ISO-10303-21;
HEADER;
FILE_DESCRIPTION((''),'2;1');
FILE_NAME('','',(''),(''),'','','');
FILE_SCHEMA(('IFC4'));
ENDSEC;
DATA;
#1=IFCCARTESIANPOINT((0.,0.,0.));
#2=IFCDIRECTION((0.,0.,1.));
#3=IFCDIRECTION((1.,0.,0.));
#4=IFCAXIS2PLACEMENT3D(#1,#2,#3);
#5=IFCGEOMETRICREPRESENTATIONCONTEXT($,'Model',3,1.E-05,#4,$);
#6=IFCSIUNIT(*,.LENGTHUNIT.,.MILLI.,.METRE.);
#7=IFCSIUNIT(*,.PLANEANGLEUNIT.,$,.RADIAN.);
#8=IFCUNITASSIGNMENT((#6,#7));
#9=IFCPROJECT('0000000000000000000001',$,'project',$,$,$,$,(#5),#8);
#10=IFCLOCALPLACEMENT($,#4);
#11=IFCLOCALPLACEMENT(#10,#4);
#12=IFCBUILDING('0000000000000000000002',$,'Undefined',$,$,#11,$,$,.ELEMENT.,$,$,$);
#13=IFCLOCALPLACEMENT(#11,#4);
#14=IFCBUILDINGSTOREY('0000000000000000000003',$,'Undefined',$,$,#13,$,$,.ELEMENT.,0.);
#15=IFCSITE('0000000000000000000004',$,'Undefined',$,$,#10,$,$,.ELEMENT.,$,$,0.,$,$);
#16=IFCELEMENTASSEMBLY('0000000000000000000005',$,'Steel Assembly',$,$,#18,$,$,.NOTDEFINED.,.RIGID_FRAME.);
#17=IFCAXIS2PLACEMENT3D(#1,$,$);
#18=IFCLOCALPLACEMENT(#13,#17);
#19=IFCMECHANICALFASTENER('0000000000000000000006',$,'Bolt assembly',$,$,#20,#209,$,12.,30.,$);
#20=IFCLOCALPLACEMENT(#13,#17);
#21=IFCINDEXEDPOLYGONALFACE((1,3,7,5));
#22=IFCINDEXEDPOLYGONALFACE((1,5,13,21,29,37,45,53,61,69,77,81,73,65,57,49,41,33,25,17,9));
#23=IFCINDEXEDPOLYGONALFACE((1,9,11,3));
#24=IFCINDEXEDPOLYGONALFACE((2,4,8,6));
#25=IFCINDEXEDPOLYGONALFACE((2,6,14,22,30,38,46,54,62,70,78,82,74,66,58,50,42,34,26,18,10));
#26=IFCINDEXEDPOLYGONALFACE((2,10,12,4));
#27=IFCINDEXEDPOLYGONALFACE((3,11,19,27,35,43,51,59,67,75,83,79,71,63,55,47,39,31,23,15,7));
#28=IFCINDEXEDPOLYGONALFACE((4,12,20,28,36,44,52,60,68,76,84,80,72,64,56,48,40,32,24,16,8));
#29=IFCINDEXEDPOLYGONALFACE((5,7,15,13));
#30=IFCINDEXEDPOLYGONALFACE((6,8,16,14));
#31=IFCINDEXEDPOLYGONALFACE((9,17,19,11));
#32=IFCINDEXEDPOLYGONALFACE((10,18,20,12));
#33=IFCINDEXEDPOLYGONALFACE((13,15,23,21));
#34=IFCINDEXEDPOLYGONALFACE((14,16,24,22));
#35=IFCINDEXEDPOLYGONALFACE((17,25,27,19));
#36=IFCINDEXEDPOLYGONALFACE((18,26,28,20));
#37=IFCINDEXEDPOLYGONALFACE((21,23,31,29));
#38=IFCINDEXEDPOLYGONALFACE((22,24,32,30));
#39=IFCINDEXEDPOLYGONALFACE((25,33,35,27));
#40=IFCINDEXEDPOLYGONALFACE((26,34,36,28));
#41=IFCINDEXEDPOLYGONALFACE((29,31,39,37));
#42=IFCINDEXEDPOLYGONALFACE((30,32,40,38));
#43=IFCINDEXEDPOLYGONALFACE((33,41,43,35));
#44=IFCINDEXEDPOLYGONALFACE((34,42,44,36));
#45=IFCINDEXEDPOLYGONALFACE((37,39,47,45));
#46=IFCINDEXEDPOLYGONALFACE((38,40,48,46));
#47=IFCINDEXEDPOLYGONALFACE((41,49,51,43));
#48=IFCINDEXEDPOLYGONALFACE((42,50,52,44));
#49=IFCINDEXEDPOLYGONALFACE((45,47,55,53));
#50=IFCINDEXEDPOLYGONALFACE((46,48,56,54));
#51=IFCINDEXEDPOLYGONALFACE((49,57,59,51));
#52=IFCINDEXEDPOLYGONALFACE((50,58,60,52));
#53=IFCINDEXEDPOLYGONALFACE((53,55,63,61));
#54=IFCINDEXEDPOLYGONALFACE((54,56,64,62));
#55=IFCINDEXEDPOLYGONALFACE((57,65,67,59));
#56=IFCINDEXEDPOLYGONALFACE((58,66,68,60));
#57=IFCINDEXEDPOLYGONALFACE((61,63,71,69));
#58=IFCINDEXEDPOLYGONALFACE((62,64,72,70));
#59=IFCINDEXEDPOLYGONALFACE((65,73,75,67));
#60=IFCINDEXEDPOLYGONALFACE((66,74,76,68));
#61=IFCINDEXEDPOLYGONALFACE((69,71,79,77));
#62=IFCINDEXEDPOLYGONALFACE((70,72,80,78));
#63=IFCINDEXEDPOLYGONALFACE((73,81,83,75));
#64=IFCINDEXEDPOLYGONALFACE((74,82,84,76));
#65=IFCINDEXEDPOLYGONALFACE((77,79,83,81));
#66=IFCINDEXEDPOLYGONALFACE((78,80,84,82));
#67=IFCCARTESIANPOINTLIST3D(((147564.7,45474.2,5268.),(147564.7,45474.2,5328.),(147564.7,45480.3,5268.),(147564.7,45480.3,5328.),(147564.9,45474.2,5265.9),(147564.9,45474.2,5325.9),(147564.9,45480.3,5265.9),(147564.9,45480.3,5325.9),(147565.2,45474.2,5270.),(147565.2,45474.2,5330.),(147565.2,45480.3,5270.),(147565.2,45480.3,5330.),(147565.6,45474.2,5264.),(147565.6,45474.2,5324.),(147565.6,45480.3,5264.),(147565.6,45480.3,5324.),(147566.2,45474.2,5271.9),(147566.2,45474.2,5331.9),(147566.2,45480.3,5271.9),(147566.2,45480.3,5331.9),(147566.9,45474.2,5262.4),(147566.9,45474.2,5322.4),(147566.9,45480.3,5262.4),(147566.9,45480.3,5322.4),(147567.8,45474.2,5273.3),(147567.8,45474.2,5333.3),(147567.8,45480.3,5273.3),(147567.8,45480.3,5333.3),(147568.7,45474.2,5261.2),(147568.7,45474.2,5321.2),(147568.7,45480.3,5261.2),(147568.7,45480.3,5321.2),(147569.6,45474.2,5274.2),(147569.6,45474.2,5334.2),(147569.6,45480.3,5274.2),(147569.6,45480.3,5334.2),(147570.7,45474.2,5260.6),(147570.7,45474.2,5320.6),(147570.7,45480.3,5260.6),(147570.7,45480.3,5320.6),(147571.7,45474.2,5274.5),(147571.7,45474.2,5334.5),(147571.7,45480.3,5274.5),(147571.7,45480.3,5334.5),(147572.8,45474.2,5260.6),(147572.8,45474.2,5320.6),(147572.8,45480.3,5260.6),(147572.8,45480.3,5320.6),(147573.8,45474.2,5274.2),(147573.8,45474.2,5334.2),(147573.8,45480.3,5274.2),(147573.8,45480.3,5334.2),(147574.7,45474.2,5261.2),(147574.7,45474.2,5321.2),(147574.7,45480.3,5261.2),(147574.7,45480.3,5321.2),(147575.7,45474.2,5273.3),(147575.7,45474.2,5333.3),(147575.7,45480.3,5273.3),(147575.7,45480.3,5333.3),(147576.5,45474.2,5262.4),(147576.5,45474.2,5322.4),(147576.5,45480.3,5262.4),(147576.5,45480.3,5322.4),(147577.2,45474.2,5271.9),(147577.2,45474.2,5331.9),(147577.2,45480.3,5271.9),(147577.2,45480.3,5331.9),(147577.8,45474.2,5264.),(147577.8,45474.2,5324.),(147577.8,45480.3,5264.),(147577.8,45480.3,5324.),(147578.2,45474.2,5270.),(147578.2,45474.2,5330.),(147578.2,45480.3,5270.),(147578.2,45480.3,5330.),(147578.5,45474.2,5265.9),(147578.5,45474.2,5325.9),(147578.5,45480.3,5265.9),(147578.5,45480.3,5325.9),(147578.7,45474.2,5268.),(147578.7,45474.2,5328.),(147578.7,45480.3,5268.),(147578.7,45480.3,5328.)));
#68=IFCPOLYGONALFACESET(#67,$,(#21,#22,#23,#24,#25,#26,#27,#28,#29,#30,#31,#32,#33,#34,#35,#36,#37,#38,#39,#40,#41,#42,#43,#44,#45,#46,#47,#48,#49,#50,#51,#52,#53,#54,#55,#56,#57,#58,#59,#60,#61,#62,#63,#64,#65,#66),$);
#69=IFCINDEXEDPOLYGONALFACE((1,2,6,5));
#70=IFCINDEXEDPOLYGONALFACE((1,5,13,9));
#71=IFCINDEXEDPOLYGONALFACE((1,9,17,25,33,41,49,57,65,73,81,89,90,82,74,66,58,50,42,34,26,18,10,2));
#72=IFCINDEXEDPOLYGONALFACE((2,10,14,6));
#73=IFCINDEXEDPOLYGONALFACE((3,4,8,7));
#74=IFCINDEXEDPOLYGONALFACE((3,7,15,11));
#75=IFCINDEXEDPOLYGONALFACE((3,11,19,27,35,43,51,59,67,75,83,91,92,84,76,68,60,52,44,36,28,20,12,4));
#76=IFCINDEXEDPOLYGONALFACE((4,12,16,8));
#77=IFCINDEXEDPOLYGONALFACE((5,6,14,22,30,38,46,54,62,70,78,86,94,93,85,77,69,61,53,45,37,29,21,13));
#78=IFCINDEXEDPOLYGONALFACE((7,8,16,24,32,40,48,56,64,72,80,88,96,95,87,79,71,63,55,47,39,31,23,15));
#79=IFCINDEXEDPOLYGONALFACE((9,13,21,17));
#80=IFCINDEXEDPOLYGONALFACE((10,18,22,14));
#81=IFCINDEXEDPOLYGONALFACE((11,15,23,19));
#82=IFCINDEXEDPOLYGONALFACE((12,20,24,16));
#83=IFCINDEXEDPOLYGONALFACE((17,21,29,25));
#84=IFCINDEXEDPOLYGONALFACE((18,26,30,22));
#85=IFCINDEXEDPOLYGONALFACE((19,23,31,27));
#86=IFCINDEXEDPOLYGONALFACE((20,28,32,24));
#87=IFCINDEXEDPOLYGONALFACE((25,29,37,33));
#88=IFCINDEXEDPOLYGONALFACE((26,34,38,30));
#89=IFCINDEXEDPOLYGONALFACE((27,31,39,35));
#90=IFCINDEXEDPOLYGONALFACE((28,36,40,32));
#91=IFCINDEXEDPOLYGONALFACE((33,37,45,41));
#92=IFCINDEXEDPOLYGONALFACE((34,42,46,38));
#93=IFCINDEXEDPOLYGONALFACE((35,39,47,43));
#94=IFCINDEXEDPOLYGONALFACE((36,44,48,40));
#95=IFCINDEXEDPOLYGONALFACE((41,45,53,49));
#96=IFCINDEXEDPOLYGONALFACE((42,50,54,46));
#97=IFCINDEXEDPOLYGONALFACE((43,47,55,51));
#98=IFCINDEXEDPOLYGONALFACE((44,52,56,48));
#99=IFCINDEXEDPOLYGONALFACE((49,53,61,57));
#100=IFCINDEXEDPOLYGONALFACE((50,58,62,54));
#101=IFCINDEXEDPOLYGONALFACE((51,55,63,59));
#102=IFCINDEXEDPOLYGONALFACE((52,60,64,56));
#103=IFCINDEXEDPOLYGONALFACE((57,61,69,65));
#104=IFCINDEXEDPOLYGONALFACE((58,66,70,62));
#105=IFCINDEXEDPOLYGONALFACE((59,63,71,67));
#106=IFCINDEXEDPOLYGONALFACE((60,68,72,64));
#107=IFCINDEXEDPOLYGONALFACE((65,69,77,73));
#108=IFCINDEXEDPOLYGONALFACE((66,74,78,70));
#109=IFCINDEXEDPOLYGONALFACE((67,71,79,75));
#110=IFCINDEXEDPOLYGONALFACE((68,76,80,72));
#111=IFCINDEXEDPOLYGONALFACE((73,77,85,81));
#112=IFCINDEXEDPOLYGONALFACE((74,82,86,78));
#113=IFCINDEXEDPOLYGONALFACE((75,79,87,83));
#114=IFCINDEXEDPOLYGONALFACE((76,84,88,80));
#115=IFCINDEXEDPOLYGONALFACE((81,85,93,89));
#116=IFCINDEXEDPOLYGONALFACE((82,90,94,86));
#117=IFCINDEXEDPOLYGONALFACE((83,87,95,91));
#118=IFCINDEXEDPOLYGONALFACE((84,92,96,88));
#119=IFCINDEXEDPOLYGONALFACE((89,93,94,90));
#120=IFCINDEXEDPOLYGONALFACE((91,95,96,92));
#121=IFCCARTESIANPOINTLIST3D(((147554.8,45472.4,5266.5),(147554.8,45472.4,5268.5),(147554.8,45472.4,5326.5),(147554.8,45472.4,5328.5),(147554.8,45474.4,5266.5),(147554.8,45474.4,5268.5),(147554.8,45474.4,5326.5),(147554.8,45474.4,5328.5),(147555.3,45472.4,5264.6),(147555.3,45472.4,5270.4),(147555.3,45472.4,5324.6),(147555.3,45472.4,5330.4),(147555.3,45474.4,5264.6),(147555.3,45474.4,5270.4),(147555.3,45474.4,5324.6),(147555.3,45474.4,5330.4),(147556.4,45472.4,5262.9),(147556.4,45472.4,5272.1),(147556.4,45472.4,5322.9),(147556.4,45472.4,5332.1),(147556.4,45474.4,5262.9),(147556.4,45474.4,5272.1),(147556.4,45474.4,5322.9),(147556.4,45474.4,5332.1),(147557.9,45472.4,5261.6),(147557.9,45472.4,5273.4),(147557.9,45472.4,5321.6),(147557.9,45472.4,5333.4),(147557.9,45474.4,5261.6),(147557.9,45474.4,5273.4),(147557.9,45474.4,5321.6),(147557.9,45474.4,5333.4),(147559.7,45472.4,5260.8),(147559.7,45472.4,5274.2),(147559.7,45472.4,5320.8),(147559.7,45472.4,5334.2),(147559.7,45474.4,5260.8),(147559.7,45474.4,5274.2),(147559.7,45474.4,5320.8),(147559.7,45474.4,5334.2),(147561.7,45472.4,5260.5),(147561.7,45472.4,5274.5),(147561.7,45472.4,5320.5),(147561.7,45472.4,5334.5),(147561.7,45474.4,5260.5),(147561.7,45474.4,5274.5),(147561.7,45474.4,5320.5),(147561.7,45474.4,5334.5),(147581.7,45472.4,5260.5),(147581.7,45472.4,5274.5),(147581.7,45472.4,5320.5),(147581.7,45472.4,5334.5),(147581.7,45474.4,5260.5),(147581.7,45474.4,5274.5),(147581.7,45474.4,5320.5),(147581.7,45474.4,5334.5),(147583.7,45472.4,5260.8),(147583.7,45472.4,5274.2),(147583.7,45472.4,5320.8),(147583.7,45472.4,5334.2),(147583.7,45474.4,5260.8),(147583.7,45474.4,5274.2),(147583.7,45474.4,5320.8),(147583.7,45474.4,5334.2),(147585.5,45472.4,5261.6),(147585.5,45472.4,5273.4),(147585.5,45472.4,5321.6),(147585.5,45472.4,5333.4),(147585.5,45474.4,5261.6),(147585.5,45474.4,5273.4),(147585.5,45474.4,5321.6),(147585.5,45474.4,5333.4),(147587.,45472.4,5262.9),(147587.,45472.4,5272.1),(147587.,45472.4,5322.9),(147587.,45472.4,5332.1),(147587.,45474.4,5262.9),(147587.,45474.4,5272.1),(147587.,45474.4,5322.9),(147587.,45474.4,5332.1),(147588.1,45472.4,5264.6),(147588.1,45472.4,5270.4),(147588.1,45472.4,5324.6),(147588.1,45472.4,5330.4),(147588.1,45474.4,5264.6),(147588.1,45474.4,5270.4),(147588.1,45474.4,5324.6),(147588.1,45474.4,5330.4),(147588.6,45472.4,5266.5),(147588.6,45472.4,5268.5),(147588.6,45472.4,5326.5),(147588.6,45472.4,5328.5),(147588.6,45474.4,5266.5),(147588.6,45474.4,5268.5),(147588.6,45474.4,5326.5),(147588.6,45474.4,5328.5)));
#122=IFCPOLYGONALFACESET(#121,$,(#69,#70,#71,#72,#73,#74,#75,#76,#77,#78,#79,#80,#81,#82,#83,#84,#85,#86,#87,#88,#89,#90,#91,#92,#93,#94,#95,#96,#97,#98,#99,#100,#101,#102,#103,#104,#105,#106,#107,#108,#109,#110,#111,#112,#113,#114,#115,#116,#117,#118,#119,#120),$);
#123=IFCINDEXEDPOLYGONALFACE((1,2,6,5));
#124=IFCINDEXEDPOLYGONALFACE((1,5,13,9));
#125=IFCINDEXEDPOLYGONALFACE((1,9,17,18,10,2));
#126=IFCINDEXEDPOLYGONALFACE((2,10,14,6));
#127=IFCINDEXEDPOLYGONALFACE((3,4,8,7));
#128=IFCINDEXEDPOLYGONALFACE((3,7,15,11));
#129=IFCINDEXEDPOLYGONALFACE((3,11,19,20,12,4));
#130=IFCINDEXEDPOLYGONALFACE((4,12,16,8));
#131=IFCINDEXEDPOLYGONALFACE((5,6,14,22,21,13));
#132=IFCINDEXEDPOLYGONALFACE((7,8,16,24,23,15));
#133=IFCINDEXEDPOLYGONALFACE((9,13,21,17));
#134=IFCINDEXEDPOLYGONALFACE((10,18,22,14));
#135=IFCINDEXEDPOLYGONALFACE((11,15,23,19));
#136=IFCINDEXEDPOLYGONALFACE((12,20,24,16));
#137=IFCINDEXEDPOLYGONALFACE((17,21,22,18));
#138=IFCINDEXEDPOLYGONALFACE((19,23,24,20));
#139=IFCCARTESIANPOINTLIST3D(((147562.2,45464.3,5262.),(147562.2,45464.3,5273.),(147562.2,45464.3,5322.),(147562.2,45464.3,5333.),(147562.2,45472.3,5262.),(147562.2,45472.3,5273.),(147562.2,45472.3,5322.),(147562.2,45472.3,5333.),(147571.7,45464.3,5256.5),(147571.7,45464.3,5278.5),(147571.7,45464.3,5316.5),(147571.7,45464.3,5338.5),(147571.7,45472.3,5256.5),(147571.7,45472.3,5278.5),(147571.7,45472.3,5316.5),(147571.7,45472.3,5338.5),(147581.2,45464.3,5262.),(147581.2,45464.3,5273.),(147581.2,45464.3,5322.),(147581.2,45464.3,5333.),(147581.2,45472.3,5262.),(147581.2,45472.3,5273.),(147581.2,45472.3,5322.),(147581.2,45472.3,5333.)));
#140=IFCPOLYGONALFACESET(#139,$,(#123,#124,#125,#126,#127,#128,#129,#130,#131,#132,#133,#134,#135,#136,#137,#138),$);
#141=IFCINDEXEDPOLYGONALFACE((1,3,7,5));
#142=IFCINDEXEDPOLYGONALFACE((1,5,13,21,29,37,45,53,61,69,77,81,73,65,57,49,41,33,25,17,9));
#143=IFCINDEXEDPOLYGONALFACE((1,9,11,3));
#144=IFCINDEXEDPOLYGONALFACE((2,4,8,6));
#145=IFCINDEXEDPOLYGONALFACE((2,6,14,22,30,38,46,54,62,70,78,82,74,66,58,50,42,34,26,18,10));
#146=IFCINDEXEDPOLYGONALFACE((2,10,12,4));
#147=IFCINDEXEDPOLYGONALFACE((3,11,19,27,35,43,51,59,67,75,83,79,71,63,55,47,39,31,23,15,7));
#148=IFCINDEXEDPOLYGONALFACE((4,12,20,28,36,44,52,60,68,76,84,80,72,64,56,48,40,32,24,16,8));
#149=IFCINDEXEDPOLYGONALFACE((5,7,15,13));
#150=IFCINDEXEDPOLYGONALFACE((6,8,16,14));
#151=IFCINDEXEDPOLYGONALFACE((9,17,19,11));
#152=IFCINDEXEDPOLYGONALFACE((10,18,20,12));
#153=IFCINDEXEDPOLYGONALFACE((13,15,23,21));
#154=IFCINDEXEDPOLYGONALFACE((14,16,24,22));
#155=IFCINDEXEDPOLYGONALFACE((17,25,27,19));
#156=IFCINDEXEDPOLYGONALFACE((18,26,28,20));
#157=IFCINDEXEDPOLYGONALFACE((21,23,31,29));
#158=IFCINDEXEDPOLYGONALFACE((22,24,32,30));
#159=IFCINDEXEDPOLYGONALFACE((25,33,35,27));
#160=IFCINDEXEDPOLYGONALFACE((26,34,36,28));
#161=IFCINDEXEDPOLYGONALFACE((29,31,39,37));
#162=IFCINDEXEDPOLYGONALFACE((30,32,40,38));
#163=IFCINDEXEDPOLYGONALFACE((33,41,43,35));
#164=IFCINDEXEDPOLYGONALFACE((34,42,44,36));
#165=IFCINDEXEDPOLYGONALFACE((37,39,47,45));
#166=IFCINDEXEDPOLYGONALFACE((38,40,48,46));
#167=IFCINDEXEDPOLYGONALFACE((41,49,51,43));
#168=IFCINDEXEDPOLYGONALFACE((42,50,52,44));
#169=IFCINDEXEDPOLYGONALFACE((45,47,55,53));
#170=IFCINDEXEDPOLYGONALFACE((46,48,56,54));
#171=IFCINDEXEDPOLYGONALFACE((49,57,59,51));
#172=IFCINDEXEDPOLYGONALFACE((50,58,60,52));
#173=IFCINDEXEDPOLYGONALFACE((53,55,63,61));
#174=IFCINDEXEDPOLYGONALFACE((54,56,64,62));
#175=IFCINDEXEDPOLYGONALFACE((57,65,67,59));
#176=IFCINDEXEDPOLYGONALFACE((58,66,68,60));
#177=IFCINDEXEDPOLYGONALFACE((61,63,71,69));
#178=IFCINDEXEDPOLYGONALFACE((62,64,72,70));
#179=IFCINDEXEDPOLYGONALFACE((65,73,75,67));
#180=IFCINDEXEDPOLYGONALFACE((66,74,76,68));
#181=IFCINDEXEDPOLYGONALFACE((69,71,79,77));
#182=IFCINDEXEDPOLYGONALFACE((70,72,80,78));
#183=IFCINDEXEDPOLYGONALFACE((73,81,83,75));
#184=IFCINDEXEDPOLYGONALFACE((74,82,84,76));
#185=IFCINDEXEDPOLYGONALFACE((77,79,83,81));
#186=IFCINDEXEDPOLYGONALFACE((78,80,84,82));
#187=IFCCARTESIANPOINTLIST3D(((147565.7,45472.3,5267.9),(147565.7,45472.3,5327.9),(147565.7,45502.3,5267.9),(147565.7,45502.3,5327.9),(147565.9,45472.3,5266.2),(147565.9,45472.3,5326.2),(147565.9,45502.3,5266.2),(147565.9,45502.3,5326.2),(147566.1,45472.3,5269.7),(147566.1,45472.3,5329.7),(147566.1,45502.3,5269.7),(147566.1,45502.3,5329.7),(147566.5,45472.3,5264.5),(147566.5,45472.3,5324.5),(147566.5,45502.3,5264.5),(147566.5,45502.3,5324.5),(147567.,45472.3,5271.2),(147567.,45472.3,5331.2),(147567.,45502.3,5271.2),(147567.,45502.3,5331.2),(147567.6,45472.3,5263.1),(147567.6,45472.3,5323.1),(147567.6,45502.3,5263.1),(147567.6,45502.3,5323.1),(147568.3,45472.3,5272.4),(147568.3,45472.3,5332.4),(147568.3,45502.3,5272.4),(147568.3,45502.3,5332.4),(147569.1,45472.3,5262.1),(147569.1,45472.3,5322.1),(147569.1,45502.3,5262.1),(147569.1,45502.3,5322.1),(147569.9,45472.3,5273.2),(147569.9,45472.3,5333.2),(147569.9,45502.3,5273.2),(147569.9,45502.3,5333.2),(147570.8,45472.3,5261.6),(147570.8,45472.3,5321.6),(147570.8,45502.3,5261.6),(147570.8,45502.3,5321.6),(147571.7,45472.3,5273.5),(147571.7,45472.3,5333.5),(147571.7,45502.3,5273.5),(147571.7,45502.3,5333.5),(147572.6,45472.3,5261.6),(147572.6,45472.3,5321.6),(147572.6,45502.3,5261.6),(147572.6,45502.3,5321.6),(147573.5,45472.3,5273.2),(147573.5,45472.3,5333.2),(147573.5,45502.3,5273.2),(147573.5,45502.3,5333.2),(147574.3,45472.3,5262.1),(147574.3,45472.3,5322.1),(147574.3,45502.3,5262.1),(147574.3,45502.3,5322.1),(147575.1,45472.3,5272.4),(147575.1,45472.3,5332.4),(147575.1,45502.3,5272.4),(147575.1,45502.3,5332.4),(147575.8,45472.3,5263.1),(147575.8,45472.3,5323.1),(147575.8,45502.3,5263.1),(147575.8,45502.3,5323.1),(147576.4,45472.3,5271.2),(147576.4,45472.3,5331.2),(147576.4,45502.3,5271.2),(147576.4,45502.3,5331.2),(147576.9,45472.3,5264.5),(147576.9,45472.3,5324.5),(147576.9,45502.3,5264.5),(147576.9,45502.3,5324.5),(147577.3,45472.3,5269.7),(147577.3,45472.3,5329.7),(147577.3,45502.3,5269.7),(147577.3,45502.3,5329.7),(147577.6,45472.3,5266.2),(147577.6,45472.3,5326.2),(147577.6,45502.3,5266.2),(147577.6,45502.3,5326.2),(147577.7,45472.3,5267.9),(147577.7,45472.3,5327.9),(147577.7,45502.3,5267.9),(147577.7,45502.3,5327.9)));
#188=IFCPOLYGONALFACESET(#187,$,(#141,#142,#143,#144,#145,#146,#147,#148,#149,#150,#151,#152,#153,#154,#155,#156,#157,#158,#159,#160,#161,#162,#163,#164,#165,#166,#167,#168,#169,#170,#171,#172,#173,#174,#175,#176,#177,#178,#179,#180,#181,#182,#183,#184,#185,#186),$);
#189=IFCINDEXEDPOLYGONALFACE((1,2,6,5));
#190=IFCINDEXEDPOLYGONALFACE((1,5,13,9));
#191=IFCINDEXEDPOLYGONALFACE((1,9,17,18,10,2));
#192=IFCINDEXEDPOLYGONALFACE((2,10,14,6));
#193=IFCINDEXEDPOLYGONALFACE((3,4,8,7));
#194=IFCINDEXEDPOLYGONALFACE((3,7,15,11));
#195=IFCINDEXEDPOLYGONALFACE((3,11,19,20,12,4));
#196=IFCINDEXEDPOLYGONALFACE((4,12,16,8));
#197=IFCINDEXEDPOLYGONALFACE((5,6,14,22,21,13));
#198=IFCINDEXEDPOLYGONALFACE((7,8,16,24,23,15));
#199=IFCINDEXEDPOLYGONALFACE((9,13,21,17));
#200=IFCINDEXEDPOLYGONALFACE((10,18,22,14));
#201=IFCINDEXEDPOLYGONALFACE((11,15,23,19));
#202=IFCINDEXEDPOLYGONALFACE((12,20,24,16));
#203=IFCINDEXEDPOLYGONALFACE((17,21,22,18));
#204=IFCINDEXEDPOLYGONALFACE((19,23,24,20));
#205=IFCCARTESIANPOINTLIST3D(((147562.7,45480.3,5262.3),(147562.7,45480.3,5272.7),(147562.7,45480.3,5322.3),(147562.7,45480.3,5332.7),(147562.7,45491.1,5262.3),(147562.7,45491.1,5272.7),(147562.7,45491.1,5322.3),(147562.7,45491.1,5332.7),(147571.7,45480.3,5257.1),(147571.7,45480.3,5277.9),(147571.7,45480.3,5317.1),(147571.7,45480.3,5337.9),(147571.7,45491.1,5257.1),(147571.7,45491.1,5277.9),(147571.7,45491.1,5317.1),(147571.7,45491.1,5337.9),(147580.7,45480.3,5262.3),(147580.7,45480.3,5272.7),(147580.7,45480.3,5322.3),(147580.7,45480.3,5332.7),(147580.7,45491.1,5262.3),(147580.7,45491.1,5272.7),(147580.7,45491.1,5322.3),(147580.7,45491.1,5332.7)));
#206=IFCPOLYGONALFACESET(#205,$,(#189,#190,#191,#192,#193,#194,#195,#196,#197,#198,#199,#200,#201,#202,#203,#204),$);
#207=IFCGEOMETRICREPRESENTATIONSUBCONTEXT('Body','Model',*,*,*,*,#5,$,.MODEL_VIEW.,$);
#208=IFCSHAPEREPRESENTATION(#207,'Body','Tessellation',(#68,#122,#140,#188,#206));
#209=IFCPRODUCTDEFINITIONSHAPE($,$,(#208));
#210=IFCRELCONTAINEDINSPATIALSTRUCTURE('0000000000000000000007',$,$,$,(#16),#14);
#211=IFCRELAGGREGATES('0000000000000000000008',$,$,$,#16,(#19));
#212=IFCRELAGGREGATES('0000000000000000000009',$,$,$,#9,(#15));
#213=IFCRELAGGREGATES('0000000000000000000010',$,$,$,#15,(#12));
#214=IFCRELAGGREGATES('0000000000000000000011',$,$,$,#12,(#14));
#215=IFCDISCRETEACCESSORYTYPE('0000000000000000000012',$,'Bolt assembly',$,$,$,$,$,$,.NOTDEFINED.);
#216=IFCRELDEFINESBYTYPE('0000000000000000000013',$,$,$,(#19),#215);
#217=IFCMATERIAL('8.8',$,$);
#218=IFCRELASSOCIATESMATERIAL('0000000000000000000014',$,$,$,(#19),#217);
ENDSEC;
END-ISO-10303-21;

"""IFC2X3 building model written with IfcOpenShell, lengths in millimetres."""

from ifc_helpers import new_model, si_unit, frame, frame_2d, origin_with_axes, origin_2d_with_axis, place, context, subcontext, project, spatial, polyline, circle_curve, parameter, trimmed, segment, composite_curve, circle, outline, extrude, source, transform, mapped, material, type_object, element, aggregate, save


model = new_model("IFC2X3")

# Units and contexts
model_context = context("Model", 3, precision=1e-05, world=origin_with_axes())
body_context = subcontext(model_context, "Body", "Model", "MODEL_VIEW")
ifc_project = project(units=[si_unit("LENGTHUNIT", "METRE", prefix="MILLI"), si_unit("PLANEANGLEUNIT", "RADIAN")], contexts=[model_context])

# Site, building, storey
site_placement = place(None, origin_with_axes())
site = spatial("IfcSite", under=ifc_project, at=site_placement, Name="Undefined", CompositionType="ELEMENT", RefElevation=0.0)
building_placement = place(site_placement, origin_with_axes())
building = spatial("IfcBuilding", under=site, at=building_placement, Name="Undefined", CompositionType="ELEMENT")
storey_placement = place(building_placement, origin_with_axes())
storey = spatial("IfcBuildingStorey", under=building, at=storey_placement, Name="Undefined", CompositionType="ELEMENT", Elevation=0.0)

# Element assembly
assembly_1_placement = place(storey_placement, origin_with_axes())
assembly_1 = element("IfcElementAssembly", 1, at=assembly_1_placement, inside=storey, Name="Steel Assembly", AssemblyPlace="NOTDEFINED", PredefinedType="RIGID_FRAME")

# Shared definitions
discrete_accessory_type_1 = type_object("IfcDiscreteAccessoryType", Name="Bolt assembly")
ifc_material_1 = material(Name="8.8")

# Mechanical fastener
shared_shape_1 = source(origin_with_axes(), body_context, "Body", "SweptSolid", [
    extrude(circle(Radius=7.0, at=origin_2d_with_axis()), frame((0.0, -3.1, 0.0), z_axis=(0.0, 1.0, 0.0), x_axis=(1.0, 0.0, 0.0)), (0.0, 0.0, 1.0), 6.1),
    extrude(outline(composite_curve([segment(polyline([(7.0, 10.0), (7.0, -10.0)]), True, "CONTINUOUS"), segment(trimmed(circle_curve(frame_2d((0.0, -10.0), x_axis=(1.0, 0.0)), 7.0), [parameter(0.0)], [parameter(3.1416)], False, "PARAMETER"), True, "CONTINUOUS"), segment(polyline([(-7.0, -10.0), (-7.0, 10.0)]), True, "CONTINUOUS"), segment(trimmed(circle_curve(frame_2d((0.0, 10.0), x_axis=(-1.0, 0.0)), 7.0), [parameter(0.0)], [parameter(3.1416)], False, "PARAMETER"), True, "DISCONTINUOUS")], self_intersect=False)), frame((0.0, -4.9, 0.0), z_axis=(0.0, 1.0, 0.0), x_axis=(1.0, 0.0, 0.0)), (0.0, 0.0, 1.0), 2.0),
    extrude(outline(polyline([(11.0, 0.0), (5.5, 9.5), (-5.5, 9.5), (-11.0, 0.0), (-5.5, -9.5), (5.5, -9.5), (11.0, 0.0)])), frame((0.0, -13.0, 0.0), z_axis=(0.0, 1.0, 0.0), x_axis=(1.0, 0.0, 0.0)), (0.0, 0.0, 1.0), 8.0),
    extrude(circle(Radius=6.0, at=origin_2d_with_axis()), frame((0.0, -5.0, 0.0), z_axis=(0.0, 1.0, 0.0), x_axis=(1.0, 0.0, 0.0)), (0.0, 0.0, 1.0), 30.0),
    extrude(outline(polyline([(10.4, 0.0), (5.2, 9.0), (-5.2, 9.0), (-10.4, 0.0), (-5.2, -9.0), (5.2, -9.0), (10.4, 0.0)])), frame((0.0, 3.0, 0.0), z_axis=(0.0, 1.0, 0.0), x_axis=(1.0, 0.0, 0.0)), (0.0, 0.0, 1.0), 10.8),
])
mechanical_fastener_1_placement = place(assembly_1_placement, frame((147616.7, 45477.3, 5222.5), z_axis=(-1.0, 0.0, 0.0), x_axis=(0.0, 0.0, 1.0)))
mechanical_fastener_1 = element("IfcMechanicalFastener", 2, at=mechanical_fastener_1_placement, type_object=discrete_accessory_type_1, material=ifc_material_1, Name="Bolt assembly", NominalDiameter=12.0, NominalLength=30.0, context=body_context, shape_type="MappedRepresentation", body=[
    mapped(shared_shape_1, transform((45.0, 0.0, 45.0))),
    mapped(shared_shape_1, transform((105.0, 0.0, 45.0))),
])
aggregate(assembly_1, [mechanical_fastener_1])

save(model, "model.ifc")
